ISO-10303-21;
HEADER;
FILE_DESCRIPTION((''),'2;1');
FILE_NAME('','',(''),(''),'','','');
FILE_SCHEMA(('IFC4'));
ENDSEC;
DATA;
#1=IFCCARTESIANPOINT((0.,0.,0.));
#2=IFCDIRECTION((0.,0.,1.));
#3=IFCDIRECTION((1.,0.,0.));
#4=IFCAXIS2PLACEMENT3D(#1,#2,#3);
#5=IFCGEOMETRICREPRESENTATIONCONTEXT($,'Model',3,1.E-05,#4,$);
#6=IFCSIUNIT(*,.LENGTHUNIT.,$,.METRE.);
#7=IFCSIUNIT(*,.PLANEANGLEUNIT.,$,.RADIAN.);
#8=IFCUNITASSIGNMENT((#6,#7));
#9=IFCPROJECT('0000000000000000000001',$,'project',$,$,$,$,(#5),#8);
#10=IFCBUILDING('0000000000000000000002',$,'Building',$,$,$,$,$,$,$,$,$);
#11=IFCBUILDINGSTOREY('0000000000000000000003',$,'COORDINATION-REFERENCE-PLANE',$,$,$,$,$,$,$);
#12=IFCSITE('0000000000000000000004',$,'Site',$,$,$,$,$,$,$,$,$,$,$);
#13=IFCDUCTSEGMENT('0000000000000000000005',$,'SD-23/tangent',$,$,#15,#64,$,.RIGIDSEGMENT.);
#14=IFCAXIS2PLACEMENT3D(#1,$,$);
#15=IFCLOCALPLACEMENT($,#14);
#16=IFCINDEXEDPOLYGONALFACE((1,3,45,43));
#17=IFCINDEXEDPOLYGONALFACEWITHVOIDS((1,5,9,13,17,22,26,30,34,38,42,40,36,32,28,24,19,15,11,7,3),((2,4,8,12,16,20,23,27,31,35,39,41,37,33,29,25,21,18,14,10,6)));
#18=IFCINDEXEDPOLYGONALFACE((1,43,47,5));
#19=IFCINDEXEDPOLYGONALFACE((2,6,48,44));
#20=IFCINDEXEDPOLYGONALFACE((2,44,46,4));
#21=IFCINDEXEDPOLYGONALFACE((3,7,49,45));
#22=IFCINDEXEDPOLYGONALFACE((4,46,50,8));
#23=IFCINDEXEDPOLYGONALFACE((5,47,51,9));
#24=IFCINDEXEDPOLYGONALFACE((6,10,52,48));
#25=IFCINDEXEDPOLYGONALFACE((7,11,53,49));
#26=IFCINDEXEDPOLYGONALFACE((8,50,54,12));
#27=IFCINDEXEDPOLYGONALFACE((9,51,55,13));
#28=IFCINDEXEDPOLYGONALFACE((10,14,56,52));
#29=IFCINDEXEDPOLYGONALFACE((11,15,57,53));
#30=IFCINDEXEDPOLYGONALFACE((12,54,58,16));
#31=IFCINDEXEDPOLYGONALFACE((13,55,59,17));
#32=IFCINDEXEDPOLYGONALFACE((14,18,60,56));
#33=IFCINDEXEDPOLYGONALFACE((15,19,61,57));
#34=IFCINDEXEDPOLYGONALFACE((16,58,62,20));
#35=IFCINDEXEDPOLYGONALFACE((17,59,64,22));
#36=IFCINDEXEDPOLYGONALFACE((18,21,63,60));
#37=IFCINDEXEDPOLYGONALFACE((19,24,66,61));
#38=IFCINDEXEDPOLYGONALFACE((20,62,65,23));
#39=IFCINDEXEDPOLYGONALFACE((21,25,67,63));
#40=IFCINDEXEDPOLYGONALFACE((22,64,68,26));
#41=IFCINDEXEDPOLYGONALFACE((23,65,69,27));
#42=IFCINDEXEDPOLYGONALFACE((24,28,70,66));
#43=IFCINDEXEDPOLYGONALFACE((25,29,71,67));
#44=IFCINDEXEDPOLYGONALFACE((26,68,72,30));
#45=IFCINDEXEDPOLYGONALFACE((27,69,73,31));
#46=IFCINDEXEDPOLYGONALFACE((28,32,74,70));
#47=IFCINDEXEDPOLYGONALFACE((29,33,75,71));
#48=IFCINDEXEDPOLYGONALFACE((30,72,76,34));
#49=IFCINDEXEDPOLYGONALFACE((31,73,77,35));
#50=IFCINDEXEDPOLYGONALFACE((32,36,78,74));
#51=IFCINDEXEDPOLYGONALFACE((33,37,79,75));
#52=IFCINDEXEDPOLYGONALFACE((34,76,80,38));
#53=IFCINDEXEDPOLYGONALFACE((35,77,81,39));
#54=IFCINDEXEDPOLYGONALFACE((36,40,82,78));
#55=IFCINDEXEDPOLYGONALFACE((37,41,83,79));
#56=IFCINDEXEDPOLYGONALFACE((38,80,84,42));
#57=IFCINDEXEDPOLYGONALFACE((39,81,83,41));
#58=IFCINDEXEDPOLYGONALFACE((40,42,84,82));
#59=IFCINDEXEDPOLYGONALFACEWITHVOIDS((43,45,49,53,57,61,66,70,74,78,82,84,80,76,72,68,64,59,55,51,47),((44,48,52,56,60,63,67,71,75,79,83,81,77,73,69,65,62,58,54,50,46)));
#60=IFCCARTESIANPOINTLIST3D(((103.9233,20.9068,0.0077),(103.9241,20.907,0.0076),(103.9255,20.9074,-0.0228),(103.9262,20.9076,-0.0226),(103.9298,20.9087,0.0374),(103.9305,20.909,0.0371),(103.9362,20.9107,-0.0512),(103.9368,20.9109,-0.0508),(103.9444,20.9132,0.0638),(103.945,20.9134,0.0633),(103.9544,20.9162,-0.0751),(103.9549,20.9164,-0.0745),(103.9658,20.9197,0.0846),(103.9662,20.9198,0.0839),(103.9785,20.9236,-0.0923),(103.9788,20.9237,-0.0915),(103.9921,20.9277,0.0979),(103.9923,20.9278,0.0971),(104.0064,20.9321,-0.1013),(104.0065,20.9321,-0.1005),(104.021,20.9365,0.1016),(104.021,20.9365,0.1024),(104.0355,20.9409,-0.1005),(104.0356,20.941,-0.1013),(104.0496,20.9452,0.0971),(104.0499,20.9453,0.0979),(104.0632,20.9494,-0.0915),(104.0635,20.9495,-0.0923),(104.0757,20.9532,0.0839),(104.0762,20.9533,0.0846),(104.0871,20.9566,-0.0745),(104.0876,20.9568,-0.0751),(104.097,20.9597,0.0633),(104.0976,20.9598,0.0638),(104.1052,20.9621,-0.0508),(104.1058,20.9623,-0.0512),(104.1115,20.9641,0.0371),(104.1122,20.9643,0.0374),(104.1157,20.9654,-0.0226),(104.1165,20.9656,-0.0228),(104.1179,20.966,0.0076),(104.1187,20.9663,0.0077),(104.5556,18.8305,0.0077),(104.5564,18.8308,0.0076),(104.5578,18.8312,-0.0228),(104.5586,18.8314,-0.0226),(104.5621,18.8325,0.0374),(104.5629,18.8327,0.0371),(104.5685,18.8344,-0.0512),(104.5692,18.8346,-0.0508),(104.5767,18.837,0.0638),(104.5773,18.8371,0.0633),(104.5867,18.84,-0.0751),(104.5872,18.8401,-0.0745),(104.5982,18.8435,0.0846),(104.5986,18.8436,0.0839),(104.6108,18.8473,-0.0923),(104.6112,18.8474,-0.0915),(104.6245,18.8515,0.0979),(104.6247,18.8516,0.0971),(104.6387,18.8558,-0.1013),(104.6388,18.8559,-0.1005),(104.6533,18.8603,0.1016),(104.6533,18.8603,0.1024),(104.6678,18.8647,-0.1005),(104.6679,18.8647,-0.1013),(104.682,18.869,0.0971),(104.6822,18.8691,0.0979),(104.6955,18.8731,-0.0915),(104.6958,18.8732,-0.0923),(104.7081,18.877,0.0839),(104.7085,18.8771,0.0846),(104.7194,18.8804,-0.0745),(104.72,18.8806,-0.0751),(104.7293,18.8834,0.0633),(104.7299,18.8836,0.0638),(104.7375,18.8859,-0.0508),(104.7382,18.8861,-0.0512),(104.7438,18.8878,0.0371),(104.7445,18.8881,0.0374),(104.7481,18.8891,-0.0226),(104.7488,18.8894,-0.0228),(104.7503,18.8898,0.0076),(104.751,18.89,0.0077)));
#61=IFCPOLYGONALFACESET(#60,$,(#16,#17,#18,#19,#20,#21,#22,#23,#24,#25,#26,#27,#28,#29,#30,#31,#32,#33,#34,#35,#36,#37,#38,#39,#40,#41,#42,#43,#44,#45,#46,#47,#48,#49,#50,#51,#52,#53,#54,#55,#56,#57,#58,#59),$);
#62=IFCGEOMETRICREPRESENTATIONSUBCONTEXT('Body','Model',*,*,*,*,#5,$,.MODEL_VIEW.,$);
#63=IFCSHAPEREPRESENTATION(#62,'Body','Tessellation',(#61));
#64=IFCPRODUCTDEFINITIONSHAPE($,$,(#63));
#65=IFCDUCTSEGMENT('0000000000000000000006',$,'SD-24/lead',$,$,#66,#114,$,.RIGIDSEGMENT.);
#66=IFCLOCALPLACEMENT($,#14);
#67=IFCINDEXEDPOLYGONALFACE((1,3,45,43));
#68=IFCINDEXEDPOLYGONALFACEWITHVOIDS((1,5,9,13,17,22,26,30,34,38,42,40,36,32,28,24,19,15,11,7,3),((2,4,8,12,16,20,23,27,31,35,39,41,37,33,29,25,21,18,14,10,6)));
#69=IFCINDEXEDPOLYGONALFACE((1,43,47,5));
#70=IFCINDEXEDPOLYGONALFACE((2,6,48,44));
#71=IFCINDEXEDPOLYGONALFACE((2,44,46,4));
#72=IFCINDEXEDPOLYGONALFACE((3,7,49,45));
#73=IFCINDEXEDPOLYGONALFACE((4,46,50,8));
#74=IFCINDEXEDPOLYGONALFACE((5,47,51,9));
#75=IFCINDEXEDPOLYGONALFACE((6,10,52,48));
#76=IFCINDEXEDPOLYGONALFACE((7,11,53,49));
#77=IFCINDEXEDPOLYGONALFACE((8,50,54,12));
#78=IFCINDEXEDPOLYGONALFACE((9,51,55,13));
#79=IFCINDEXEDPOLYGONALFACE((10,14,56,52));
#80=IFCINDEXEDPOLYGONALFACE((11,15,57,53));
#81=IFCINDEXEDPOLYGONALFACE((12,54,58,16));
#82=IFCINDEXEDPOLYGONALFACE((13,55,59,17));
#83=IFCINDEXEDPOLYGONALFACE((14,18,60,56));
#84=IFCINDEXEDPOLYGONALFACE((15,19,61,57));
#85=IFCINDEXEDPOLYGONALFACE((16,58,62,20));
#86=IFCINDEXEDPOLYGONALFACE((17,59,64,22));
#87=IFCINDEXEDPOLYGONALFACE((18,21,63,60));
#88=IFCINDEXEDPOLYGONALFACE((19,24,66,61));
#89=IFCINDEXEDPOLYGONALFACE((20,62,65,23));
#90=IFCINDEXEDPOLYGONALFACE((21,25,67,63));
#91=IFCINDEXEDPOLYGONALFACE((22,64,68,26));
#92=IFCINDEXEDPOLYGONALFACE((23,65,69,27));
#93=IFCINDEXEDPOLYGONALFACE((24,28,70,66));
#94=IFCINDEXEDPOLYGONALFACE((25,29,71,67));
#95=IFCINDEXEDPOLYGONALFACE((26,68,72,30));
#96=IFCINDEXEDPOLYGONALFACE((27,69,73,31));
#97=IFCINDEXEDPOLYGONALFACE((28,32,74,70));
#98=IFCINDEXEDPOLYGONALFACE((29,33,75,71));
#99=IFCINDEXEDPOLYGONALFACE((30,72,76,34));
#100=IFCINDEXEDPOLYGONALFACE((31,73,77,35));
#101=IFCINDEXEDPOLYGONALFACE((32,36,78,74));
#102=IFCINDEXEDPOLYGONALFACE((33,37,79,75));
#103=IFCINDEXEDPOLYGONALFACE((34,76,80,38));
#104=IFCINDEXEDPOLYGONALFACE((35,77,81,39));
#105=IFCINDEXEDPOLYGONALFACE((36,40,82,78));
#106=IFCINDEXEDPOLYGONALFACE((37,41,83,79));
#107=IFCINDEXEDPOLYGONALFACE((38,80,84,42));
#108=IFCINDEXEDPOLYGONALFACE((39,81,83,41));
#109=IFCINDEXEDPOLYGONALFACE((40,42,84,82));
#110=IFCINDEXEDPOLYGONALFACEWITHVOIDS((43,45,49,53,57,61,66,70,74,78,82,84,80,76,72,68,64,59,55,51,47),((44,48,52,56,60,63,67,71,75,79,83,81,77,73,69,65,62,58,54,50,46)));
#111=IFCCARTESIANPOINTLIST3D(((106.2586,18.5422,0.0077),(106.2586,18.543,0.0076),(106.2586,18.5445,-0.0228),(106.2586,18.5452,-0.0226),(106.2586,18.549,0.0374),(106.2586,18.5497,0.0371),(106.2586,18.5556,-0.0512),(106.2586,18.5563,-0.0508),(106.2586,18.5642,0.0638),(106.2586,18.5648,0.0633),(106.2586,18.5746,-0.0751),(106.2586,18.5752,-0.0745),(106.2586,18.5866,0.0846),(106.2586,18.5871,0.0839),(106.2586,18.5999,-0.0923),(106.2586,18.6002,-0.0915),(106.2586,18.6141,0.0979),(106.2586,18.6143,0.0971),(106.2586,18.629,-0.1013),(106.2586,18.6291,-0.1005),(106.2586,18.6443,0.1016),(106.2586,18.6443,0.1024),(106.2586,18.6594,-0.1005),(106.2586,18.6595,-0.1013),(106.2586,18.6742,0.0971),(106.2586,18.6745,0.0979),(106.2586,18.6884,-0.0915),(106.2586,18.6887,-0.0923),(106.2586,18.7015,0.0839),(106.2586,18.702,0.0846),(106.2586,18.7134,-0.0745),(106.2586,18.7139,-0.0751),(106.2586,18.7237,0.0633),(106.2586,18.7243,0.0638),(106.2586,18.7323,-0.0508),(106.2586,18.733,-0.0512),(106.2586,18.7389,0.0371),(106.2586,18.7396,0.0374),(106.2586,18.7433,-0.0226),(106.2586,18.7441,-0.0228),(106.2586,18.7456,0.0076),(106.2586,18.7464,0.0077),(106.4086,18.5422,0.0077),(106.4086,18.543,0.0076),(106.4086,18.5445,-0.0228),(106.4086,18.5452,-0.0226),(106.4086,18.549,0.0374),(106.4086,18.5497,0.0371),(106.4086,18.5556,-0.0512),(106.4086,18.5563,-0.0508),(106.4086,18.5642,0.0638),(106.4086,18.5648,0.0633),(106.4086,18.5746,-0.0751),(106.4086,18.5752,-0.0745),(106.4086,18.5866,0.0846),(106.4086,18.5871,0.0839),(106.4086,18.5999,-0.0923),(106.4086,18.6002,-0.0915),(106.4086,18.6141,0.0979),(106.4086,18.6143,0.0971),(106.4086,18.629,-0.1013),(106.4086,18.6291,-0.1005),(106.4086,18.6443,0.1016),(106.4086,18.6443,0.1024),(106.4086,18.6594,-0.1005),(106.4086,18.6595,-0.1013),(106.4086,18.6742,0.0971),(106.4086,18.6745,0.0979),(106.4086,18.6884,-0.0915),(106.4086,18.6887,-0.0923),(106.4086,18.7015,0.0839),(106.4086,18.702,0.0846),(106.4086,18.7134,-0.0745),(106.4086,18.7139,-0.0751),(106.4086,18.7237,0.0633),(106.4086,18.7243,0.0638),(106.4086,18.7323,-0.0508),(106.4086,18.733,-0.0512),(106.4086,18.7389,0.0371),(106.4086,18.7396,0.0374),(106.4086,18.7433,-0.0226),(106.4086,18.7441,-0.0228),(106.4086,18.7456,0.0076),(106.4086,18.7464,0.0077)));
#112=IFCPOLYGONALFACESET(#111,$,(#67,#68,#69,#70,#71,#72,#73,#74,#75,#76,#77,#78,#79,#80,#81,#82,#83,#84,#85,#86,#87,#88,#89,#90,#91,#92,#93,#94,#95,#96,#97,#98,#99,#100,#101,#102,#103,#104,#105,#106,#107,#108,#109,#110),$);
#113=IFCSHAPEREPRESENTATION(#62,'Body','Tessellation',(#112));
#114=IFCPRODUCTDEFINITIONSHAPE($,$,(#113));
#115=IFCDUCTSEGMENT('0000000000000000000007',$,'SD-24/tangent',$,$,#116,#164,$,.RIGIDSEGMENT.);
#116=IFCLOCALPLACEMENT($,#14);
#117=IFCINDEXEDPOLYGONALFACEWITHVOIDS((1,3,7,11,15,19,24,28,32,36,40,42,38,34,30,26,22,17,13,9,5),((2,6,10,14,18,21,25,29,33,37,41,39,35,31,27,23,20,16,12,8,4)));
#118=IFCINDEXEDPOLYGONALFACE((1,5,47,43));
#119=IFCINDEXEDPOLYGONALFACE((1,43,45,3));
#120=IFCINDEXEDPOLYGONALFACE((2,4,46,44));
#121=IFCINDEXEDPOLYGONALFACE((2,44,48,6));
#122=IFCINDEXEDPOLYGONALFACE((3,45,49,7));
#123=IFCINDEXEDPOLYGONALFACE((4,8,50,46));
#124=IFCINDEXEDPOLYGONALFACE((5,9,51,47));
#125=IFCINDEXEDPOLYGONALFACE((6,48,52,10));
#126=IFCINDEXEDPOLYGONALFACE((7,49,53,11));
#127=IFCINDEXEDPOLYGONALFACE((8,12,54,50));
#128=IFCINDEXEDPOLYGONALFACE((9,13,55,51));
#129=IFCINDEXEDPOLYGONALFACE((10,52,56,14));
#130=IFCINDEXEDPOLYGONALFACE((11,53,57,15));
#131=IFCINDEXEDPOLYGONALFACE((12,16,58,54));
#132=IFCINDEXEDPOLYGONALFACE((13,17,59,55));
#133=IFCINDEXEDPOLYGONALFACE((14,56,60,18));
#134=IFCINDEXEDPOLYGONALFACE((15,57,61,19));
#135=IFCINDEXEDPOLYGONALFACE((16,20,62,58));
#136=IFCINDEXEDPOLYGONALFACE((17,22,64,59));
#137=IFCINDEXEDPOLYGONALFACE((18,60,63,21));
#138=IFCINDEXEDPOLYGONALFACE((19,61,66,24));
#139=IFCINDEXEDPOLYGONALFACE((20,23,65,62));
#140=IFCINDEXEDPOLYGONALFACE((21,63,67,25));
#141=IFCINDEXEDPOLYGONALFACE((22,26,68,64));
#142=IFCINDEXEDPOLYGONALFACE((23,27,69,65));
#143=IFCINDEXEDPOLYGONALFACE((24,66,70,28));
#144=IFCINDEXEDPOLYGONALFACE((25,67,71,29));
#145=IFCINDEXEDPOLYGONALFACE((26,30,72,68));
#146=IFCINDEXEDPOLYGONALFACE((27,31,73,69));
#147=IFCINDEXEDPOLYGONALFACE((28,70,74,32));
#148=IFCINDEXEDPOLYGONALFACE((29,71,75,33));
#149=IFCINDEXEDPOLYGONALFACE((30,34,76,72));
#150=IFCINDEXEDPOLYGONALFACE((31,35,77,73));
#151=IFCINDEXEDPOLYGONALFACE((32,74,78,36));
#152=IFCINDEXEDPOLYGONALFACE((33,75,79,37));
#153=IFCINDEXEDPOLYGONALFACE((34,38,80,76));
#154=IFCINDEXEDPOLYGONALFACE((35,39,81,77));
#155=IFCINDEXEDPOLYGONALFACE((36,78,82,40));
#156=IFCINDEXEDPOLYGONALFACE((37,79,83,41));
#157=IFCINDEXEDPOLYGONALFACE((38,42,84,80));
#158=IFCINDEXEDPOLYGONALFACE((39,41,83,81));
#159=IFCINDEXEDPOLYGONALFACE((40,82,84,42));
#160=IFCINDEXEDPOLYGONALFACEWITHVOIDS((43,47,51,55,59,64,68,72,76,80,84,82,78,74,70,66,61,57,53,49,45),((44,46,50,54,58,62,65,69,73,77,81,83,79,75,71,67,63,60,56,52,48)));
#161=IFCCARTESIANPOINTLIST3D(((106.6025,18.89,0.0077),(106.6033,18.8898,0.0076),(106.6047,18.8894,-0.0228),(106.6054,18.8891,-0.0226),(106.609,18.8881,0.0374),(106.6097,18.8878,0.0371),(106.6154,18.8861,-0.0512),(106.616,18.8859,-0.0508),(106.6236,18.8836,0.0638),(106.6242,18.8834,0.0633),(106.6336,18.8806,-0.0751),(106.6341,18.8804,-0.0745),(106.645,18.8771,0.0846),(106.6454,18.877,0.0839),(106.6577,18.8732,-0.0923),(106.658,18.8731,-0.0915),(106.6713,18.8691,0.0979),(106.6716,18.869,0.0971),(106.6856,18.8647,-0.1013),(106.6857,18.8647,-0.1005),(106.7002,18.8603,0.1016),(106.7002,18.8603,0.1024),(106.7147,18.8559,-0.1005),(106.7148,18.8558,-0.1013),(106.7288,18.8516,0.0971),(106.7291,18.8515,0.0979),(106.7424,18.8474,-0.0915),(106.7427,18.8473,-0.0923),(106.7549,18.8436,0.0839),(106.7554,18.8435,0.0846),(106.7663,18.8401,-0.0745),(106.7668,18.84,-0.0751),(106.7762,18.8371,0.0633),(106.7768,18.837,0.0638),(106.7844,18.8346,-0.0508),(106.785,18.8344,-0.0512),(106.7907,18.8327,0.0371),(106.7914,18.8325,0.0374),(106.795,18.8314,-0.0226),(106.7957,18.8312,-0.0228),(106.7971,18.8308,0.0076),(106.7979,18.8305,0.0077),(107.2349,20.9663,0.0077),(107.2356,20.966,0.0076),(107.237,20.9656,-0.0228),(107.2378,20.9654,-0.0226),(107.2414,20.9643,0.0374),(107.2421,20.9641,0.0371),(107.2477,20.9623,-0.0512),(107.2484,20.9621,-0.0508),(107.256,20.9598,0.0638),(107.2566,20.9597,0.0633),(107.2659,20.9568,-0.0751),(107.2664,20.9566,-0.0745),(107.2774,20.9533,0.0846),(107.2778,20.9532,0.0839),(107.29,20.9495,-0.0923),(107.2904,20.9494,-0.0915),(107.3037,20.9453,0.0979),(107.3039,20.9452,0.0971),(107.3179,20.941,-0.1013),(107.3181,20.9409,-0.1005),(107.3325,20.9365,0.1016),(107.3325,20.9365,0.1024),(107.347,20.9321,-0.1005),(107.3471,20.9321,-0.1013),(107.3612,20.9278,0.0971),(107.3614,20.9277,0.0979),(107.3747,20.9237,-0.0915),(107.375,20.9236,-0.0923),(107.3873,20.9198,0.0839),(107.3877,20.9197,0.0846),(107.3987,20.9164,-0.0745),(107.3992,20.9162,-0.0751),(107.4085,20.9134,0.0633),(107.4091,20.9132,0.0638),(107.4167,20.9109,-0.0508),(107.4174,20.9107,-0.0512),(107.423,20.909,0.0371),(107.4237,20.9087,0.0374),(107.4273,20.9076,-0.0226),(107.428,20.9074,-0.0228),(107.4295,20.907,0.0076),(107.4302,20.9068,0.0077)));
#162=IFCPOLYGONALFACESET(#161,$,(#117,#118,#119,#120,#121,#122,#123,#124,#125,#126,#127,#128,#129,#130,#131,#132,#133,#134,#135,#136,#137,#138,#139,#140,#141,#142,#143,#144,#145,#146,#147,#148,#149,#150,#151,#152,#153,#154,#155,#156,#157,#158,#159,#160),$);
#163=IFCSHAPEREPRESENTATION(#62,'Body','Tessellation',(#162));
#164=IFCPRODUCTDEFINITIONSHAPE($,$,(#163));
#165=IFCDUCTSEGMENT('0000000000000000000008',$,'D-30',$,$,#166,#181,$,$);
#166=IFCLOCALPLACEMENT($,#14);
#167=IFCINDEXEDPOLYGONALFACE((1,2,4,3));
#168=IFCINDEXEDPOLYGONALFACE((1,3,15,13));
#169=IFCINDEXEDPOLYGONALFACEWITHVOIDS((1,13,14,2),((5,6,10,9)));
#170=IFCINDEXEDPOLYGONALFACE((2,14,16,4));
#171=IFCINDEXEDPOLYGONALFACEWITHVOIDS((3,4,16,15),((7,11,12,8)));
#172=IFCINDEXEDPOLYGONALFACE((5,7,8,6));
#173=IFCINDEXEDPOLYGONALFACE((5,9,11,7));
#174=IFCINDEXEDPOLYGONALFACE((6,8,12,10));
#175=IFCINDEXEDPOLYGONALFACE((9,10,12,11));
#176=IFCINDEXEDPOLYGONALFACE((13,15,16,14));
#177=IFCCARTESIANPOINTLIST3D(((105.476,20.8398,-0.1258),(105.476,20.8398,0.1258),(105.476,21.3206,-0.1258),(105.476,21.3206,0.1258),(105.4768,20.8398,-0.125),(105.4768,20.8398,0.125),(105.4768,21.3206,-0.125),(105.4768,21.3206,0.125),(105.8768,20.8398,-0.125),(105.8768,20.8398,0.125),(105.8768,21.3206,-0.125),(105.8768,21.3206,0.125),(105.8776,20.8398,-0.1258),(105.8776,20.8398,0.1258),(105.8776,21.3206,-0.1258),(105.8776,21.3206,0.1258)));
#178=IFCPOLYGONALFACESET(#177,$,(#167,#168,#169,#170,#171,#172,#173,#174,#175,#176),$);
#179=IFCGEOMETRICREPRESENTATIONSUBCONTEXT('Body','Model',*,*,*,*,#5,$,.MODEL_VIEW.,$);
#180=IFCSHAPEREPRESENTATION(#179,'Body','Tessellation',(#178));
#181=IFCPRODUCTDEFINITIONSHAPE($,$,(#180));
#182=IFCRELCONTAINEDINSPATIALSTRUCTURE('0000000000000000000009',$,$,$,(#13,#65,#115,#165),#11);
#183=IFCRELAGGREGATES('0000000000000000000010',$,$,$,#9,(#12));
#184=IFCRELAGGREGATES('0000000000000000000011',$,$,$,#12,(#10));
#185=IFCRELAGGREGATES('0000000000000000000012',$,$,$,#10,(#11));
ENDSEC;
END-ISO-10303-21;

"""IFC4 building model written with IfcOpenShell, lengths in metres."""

from ifc_helpers import new_model, si_unit, frame, origin, origin_with_axes, place, context, subcontext, project, spatial, hollow_rectangle, hollow_circle, extrude, element, save


model = new_model("IFC4")

# Units and contexts
model_context = context("Model", 3, precision=1e-05, world=origin_with_axes())
body_context_1 = subcontext(model_context, "Body", "Model", "MODEL_VIEW")
body_context_2 = subcontext(model_context, "Body", "Model", "MODEL_VIEW")
ifc_project = project(units=[si_unit("LENGTHUNIT", "METRE"), si_unit("PLANEANGLEUNIT", "RADIAN")], contexts=[model_context])

# Site, building, storey
site = spatial("IfcSite", under=ifc_project, Name="Site")
building = spatial("IfcBuilding", under=site, Name="Building")
storey = spatial("IfcBuildingStorey", under=building, Name="COORDINATION-REFERENCE-PLANE")

# Duct segment
duct_segment_1_placement = place(None, frame((104.6533, 18.8603, 0.0), z_axis=(-0.291351, 0.956616, 0.0), x_axis=(0.0, 0.0, 1.0)))
element("IfcDuctSegment", 1, at=duct_segment_1_placement, inside=storey, Name="SD-23/tangent", PredefinedType="RIGIDSEGMENT", context=body_context_1, shape_type="SweptSolid", body=[
    extrude(hollow_circle(Radius=0.1024, WallThickness=0.0008), origin_with_axes(), (0.0, 0.0, 1.0), 2.1704),
])

# Duct segment
duct_segment_2_placement = place(None, frame((106.2586, 18.6443, 0.0), z_axis=(1.0, 0.0, 0.0), x_axis=(0.0, 0.0, 1.0)))
element("IfcDuctSegment", 2, at=duct_segment_2_placement, inside=storey, Name="SD-24/lead", PredefinedType="RIGIDSEGMENT", context=body_context_1, shape_type="SweptSolid", body=[
    extrude(hollow_circle(Radius=0.1024, WallThickness=0.0008), origin_with_axes(), (0.0, 0.0, 1.0), 0.15),
])

# Duct segment
duct_segment_3_placement = place(None, frame((106.7002, 18.8603, 0.0), z_axis=(0.291351, 0.956616, 0.0), x_axis=(0.0, 0.0, 1.0)))
element("IfcDuctSegment", 3, at=duct_segment_3_placement, inside=storey, Name="SD-24/tangent", PredefinedType="RIGIDSEGMENT", context=body_context_1, shape_type="SweptSolid", body=[
    extrude(hollow_circle(Radius=0.1024, WallThickness=0.0008), origin_with_axes(), (0.0, 0.0, 1.0), 2.1704),
])

# Duct segment
duct_segment_4_placement = place(None, frame((105.6768, 20.8398, 0.0), z_axis=(0.0, 1.0, 0.0), x_axis=(1.0, 0.0, 0.0)))
element("IfcDuctSegment", 4, at=duct_segment_4_placement, inside=storey, Name="D-30", context=body_context_2, shape_type="SweptSolid", body=[
    extrude(hollow_rectangle(XDim=0.4016, YDim=0.2516, WallThickness=0.0008), origin(), (0.0, 0.0, 1.0), 0.4808),
])

save(model, "model.ifc")
